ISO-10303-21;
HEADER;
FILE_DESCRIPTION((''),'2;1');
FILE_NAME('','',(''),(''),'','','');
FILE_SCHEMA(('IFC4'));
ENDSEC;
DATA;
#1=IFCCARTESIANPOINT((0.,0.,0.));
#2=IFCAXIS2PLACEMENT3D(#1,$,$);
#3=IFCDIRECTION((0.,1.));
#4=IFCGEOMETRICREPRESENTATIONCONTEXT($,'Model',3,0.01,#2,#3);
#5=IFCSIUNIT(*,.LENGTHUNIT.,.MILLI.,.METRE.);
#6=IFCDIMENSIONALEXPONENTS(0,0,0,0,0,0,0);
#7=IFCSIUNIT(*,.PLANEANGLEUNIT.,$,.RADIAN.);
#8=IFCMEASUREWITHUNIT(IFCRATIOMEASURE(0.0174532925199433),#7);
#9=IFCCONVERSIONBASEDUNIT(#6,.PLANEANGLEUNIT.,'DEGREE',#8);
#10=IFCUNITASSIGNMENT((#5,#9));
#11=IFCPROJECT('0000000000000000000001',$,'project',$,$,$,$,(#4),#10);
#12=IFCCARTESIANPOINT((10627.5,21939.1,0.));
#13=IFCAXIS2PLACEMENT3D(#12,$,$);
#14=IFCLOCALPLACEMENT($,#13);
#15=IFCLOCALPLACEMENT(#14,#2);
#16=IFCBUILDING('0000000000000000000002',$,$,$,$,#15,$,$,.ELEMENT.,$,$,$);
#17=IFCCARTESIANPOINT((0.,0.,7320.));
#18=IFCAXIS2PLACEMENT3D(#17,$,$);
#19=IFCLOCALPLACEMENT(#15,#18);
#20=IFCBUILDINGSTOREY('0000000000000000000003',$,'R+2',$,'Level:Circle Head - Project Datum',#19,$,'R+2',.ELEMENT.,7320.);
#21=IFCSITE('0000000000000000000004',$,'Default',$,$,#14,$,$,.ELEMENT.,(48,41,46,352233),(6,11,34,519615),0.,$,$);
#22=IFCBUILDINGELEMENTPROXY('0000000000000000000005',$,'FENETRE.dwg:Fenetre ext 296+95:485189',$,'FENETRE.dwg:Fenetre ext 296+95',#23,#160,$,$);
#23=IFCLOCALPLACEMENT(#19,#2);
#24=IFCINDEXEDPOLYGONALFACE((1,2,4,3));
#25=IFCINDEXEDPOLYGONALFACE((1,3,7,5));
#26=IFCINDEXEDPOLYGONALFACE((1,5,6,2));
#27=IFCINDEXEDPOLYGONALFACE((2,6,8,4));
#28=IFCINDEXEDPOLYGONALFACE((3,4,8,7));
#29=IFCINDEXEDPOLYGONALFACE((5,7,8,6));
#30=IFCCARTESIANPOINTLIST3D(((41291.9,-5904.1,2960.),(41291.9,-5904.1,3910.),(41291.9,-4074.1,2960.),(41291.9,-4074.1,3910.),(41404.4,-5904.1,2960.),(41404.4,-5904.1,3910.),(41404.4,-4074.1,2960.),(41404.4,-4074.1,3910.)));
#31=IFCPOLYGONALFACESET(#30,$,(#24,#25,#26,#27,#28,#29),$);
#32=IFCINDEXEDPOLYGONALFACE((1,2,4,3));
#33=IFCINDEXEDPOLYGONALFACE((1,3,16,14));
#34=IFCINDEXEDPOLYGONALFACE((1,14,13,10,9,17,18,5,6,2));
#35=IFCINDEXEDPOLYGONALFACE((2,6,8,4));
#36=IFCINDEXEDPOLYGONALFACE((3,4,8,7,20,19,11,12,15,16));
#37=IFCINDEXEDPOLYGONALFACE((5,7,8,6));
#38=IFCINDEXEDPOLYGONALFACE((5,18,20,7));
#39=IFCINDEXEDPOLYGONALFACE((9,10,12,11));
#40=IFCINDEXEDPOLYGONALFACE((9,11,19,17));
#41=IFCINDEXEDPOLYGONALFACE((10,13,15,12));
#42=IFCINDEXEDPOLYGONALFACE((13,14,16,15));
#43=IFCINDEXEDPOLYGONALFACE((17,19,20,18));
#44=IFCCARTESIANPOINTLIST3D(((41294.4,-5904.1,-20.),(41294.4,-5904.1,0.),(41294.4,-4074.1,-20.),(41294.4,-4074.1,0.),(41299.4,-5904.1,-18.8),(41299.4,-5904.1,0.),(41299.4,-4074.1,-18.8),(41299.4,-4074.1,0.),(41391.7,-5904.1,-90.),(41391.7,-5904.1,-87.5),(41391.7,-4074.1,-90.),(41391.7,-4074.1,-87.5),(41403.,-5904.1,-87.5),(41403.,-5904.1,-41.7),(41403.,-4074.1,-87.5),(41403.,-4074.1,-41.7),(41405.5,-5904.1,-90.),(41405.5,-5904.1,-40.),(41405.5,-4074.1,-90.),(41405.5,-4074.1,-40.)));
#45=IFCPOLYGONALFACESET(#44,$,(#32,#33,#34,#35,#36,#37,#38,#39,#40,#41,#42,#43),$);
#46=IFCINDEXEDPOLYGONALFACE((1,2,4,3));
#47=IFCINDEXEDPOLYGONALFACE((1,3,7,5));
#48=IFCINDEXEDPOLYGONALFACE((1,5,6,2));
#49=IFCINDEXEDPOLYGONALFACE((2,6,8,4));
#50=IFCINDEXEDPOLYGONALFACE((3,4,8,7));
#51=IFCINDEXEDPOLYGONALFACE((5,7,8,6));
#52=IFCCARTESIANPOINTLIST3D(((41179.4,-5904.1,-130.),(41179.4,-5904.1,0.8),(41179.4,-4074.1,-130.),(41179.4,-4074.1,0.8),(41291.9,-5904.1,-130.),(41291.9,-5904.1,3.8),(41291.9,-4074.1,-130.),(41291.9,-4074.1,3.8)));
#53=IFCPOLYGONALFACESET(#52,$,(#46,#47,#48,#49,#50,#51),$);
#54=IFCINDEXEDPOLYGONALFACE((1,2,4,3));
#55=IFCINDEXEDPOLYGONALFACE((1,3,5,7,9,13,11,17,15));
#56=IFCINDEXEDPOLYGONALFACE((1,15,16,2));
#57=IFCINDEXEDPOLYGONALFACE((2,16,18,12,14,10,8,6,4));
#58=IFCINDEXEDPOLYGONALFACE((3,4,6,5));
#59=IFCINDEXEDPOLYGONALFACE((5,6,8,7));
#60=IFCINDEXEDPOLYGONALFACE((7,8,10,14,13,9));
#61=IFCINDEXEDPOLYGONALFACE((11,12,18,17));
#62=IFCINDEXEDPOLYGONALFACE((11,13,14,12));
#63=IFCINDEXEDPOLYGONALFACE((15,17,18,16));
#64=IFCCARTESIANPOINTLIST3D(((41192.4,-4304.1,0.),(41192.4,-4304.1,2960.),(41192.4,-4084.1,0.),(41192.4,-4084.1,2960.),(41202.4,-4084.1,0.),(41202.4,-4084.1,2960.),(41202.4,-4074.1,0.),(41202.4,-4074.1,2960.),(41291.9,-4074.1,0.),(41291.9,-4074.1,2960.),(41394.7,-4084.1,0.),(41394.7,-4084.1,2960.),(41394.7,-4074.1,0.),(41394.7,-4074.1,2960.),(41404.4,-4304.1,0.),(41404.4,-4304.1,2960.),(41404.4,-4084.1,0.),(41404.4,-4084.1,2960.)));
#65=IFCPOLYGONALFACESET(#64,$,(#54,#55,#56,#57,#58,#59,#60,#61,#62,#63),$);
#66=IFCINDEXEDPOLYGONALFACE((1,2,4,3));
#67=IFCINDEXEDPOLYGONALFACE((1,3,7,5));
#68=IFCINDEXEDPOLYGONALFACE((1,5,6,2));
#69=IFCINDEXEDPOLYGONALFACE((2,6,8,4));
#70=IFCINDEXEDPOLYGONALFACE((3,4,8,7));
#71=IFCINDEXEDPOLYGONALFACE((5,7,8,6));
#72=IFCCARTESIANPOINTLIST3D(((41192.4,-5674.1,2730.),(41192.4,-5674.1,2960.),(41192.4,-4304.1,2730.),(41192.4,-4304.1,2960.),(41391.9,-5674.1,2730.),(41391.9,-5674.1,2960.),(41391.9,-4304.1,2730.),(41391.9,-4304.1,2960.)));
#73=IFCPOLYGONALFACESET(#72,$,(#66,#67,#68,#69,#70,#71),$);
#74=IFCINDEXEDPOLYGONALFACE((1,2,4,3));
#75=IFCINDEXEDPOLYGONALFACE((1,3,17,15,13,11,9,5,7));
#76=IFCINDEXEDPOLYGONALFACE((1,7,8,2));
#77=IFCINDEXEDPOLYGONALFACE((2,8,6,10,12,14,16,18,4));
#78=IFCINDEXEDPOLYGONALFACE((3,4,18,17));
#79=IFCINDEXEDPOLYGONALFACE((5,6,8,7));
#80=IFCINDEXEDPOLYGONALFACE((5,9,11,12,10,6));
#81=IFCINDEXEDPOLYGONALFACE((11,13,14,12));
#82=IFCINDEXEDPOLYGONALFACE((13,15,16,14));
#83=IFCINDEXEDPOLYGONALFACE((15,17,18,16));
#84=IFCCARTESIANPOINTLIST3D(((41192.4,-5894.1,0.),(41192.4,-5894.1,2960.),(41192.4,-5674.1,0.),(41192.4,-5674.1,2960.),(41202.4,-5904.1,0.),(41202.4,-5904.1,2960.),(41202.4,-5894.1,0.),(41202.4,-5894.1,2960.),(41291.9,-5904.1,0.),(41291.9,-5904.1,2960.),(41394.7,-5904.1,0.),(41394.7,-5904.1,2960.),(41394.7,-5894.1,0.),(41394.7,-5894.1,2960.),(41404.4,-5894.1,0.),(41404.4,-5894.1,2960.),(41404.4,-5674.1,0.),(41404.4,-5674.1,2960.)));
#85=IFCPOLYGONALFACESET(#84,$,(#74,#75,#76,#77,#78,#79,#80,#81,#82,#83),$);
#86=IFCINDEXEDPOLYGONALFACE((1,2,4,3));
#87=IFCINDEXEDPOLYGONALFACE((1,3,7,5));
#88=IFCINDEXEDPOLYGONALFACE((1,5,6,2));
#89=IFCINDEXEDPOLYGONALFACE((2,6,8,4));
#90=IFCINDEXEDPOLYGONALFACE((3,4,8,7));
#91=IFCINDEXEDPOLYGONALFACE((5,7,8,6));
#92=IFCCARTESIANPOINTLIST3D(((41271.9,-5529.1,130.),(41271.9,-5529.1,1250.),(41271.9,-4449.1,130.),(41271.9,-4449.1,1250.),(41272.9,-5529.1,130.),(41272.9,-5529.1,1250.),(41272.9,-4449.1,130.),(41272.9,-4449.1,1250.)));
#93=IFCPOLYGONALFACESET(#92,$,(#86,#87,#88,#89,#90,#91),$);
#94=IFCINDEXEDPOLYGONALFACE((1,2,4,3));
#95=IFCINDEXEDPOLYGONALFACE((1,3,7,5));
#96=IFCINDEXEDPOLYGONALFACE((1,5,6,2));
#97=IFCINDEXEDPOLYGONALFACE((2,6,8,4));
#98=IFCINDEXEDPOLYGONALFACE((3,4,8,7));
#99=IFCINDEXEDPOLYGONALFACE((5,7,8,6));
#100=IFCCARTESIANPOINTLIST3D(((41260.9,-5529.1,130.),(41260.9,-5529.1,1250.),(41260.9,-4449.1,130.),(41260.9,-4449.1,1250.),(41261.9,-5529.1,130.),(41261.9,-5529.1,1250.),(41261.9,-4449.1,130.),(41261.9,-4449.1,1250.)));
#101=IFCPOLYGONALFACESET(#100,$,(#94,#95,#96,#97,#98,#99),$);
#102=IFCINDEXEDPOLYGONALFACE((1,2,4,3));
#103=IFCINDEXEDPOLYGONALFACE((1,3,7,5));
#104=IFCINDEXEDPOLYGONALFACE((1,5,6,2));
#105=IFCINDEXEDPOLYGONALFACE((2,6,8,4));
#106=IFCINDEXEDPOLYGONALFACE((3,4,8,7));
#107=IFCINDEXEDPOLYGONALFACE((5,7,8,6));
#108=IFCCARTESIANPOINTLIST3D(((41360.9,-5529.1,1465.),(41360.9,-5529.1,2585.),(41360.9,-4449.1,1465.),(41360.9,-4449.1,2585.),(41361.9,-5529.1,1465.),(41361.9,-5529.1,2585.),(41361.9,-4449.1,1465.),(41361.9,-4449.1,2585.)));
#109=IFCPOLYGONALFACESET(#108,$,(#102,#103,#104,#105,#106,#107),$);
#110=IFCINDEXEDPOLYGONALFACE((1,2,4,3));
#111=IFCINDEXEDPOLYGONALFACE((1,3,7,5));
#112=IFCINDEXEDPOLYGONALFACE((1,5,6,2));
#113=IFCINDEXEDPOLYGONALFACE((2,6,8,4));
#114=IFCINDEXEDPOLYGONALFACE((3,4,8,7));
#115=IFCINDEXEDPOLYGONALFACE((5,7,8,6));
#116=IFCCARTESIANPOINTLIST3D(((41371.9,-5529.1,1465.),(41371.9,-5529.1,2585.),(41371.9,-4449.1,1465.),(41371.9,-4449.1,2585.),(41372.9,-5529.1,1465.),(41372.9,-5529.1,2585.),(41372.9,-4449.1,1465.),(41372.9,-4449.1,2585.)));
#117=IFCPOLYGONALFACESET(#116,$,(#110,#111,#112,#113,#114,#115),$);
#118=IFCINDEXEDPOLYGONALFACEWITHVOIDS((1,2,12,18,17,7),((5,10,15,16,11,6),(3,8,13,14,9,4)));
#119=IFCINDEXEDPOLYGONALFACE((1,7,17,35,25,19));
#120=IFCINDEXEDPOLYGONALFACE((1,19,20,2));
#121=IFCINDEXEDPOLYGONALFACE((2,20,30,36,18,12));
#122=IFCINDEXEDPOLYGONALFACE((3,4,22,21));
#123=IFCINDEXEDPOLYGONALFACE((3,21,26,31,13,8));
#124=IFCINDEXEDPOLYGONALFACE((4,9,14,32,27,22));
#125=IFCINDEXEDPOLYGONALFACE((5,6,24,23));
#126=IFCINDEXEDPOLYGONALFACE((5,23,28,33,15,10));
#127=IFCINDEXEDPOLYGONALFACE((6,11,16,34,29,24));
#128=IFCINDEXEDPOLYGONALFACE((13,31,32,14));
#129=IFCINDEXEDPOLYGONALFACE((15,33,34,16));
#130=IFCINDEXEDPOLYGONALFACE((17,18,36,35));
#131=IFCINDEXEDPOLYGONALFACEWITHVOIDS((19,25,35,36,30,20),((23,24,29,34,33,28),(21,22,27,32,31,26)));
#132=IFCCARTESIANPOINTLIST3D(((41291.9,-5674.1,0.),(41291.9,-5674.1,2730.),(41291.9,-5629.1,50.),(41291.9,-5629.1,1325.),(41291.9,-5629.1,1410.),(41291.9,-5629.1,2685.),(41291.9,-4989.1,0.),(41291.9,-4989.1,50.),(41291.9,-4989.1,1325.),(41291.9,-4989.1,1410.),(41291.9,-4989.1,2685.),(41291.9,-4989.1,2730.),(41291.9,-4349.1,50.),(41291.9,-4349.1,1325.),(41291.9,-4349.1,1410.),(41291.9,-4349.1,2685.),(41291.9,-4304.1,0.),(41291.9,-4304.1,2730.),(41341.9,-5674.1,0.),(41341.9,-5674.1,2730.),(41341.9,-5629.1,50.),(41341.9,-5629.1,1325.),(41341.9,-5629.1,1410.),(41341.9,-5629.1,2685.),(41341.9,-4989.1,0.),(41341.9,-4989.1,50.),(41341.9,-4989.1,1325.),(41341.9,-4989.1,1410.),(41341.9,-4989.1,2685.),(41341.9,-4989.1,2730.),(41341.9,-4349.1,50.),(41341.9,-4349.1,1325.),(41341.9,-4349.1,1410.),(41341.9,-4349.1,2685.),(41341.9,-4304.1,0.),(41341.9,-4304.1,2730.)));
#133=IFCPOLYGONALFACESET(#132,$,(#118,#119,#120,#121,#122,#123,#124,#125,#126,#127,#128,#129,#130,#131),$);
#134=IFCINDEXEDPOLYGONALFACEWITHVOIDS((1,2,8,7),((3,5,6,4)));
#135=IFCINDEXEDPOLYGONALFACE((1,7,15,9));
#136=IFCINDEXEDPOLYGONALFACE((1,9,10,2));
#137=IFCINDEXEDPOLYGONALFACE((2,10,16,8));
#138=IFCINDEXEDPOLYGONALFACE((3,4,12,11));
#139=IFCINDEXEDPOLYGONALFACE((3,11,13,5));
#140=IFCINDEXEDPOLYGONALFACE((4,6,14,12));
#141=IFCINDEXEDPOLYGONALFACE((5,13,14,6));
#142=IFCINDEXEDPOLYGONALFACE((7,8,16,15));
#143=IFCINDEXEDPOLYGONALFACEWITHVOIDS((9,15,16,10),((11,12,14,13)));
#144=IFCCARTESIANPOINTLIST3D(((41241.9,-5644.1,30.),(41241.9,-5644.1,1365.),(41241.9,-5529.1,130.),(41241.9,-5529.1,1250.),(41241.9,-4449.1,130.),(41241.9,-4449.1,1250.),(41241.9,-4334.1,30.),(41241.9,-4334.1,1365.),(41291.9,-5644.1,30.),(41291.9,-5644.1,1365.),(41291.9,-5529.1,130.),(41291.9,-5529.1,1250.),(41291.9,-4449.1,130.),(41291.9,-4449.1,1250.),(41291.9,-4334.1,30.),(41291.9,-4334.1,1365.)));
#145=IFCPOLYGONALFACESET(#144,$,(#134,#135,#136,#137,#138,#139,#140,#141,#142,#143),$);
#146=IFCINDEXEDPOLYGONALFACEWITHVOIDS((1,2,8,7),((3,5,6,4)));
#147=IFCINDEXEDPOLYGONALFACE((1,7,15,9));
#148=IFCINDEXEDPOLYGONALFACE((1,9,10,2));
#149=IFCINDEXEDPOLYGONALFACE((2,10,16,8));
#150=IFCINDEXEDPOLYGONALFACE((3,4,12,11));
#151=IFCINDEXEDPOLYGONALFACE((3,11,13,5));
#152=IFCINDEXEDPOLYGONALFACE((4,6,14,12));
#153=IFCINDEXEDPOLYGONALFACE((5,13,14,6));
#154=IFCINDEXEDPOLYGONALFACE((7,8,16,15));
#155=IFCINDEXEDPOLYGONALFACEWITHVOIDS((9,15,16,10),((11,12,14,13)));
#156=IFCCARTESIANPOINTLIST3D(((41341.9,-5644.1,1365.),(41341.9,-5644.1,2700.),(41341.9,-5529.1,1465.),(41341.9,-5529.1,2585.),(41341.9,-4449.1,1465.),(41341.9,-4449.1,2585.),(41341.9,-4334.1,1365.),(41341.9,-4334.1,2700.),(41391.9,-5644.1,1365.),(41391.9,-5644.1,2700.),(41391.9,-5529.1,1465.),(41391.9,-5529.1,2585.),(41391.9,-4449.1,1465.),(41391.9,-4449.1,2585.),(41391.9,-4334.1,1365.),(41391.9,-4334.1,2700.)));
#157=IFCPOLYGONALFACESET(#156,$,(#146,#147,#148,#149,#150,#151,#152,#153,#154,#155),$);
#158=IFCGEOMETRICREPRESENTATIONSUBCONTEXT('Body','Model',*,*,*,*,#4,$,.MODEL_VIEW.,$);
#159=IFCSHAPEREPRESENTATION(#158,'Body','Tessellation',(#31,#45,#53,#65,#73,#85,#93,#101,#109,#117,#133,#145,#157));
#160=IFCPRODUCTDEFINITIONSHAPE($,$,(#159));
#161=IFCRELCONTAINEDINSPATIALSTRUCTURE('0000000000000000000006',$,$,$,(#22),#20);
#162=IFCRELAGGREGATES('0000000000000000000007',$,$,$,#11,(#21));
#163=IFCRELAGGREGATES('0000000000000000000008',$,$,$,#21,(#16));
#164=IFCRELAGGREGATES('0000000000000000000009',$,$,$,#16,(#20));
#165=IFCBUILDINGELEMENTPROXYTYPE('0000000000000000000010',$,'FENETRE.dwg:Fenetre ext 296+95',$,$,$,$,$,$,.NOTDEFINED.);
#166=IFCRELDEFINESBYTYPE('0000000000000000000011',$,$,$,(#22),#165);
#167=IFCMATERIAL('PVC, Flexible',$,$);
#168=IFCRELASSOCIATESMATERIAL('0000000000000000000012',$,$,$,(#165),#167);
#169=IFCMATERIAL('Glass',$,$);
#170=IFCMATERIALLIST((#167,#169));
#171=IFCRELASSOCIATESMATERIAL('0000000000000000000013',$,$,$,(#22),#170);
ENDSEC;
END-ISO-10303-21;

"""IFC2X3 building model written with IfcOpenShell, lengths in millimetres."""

from ifc_helpers import new_model, entity, si_unit, converted_unit, direction, frame, frame_2d, origin, origin_2d_with_axis, place, context, subcontext, project, spatial, polyline, rectangle, outline, extrude, source, transform, mapped, material, material_list, type_object, type_shapes, element, save


model = new_model("IFC2X3")

# Units and contexts
model_context = context("Model", 3, precision=0.01, world=origin(), true_north=direction((0.0, 1.0)))
body_context = subcontext(model_context, "Body", "Model", "MODEL_VIEW")
ifc_project = project(units=[si_unit("LENGTHUNIT", "METRE", prefix="MILLI"), converted_unit("PLANEANGLEUNIT", "DEGREE", entity("IfcRatioMeasure", 0.0174532925199433), si_unit("PLANEANGLEUNIT", "RADIAN"), dimensions=[0, 0, 0, 0, 0, 0, 0])], contexts=[model_context])

# Site, building, storey
site_placement = place(None, frame((10627.5, 21939.1, 0.0)))
site = spatial("IfcSite", under=ifc_project, at=site_placement, Name="Default", CompositionType="ELEMENT", RefLatitude=(48, 41, 46, 352233), RefLongitude=(6, 11, 34, 519615), RefElevation=0.0)
building_placement = place(site_placement, origin())
building = spatial("IfcBuilding", under=site, at=building_placement, CompositionType="ELEMENT")
storey_placement = place(building_placement, frame((0.0, 0.0, 7320.0)))
storey = spatial("IfcBuildingStorey", under=building, at=storey_placement, Name="R+2", ObjectType="Level:Circle Head - Project Datum", LongName="R+2", CompositionType="ELEMENT", Elevation=7320.0)

# Building element proxy
ifc_material_1 = material(Name="PVC, Flexible")
ifc_material_2 = material(Name="Glass")
building_element_proxy_type_1 = type_object("IfcBuildingElementProxyType", Name="FENETRE.dwg:Fenetre ext 296+95", PredefinedType="NOTDEFINED", material=ifc_material_1)
shared_shape_1 = source(origin(), body_context, "Body", "SweptSolid", [
    extrude(rectangle(XDim=112.5, YDim=1830.0, at=origin_2d_with_axis()), frame((-10.4, -56.3, 2960.0), z_axis=(0.0, 0.0, 1.0), x_axis=(0.0, 1.0, 0.0)), (0.0, 0.0, 1.0), 950.0),
    extrude(outline(polyline([(27.5, -64.4), (47.5, -64.4), (47.5, -59.4), (28.8, -59.4), (7.5, 46.7), (-42.5, 46.7), (-42.5, 32.9), (-40.0, 32.9), (-40.0, 44.2), (5.8, 44.2), (27.5, -64.4)])), frame((-925.4, -66.9, -47.5), z_axis=(1.0, 0.0, 0.0), x_axis=(0.0, 0.0, 1.0)), (0.0, 0.0, 1.0), 1830.0),
    extrude(outline(polyline([(-54.5, -66.1), (58.0, -66.1), (54.5, 67.6), (-58.0, 64.6), (-54.5, -66.1)])), frame((-925.4, 56.3, -63.8), z_axis=(1.0, 0.0, 0.0), x_axis=(0.0, -0.999645, 0.02665)), (0.0, 0.0, 1.0), 1830.0),
    extrude(outline(polyline([(-97.0, -55.6), (5.9, -55.6), (95.4, -55.6), (95.4, -45.6), (105.4, -45.6), (105.4, 174.4), (-106.6, 174.4), (-106.6, -45.6), (-97.0, -45.6), (-97.0, -55.6)])), frame((849.0, -5.9, 0.0), z_axis=(0.0, 0.0, 1.0), x_axis=(0.0, 1.0, 0.0)), (0.0, 0.0, 1.0), 2960.0),
    extrude(rectangle(XDim=1370.0, YDim=199.5, at=origin_2d_with_axis()), frame((-10.4, -0.3, 2730.0), z_axis=(0.0, 0.0, 1.0), x_axis=(-1.0, 0.0, 0.0)), (0.0, 0.0, 1.0), 230.0),
    extrude(outline(polyline([(-55.6, 97.0), (-55.6, -5.9), (-55.6, -95.4), (-45.6, -95.4), (-45.6, -105.4), (174.4, -105.4), (174.4, 106.6), (-45.6, 106.6), (-45.6, 97.0), (-55.6, 97.0)])), frame((-869.9, -5.9, 0.0), z_axis=(0.0, 0.0, -1.0), x_axis=(1.0, 0.0, 0.0)), (0.0, 0.0, -1.0), 2960.0),
    extrude(rectangle(XDim=1080.0, YDim=1.0, at=origin_2d_with_axis()), frame((-10.4, 19.5, 130.0), z_axis=(0.0, 0.0, 1.0), x_axis=(-1.0, 0.0, 0.0)), (0.0, 0.0, 1.0), 1120.0),
    extrude(rectangle(XDim=1080.0, YDim=1.0, at=origin_2d_with_axis()), frame((-10.4, 30.5, 130.0), z_axis=(0.0, 0.0, 1.0), x_axis=(-1.0, 0.0, 0.0)), (0.0, 0.0, 1.0), 1120.0),
    extrude(rectangle(XDim=1080.0, YDim=1.0, at=frame_2d((0.0, 0.0), x_axis=(1.0, 0.0))), frame((-10.4, -69.5, 1465.0), z_axis=(0.0, 0.0, 1.0), x_axis=(-1.0, 0.0, 0.0)), (0.0, 0.0, 1.0), 1120.0),
    extrude(rectangle(XDim=1080.0, YDim=1.0, at=frame_2d((0.0, 0.0), x_axis=(1.0, 0.0))), frame((-10.4, -80.5, 1465.0), z_axis=(0.0, 0.0, 1.0), x_axis=(-1.0, 0.0, 0.0)), (0.0, 0.0, 1.0), 1120.0),
    extrude(outline(polyline([(-685.0, -1365.0), (0.0, -1365.0), (685.0, -1365.0), (685.0, 1365.0), (0.0, 1365.0), (-685.0, 1365.0), (-685.0, -1365.0)]), holes=[polyline([(-640.0, -1320.0), (-640.0, -45.0), (0.0, -45.0), (640.0, -45.0), (640.0, -1320.0), (0.0, -1320.0), (-640.0, -1320.0)]), polyline([(-640.0, 40.0), (-640.0, 1315.0), (0.0, 1315.0), (640.0, 1315.0), (640.0, 40.0), (0.0, 40.0), (-640.0, 40.0)])]), frame((-10.4, -50.0, 1365.0), z_axis=(0.0, 1.0, 0.0), x_axis=(1.0, 0.0, 0.0)), (0.0, 0.0, 1.0), 50.0),
    extrude(outline(polyline([(-655.0, -667.5), (655.0, -667.5), (655.0, 667.5), (-655.0, 667.5), (-655.0, -667.5)]), holes=[polyline([(-540.0, 552.5), (540.0, 552.5), (540.0, -567.5), (-540.0, -567.5), (-540.0, 552.5)])]), frame((-10.4, 0.0, 697.5), z_axis=(0.0, 1.0, 0.0), x_axis=(-1.0, 0.0, 0.0)), (0.0, 0.0, 1.0), 50.0),
    extrude(outline(polyline([(-655.0, -667.5), (655.0, -667.5), (655.0, 667.5), (-655.0, 667.5), (-655.0, -667.5)]), holes=[polyline([(-540.0, 552.5), (540.0, 552.5), (540.0, -567.5), (-540.0, -567.5), (-540.0, 552.5)])]), frame((-10.4, -100.0, 2032.5), z_axis=(0.0, 1.0, 0.0), x_axis=(-1.0, 0.0, 0.0)), (0.0, 0.0, 1.0), 50.0),
])
type_shapes(building_element_proxy_type_1, [shared_shape_1])
ifc_material_list_1 = material_list([ifc_material_1, ifc_material_2])
proxy_1_placement = place(storey_placement, frame((41291.9, -4978.7, 0.0), z_axis=(0.0, 0.0, 1.0), x_axis=(0.0, 1.0, 0.0)))
element("IfcBuildingElementProxy", 1, at=proxy_1_placement, inside=storey, type_object=building_element_proxy_type_1, material=ifc_material_list_1, Name="FENETRE.dwg:Fenetre ext 296+95:485189", ObjectType="FENETRE.dwg:Fenetre ext 296+95", context=body_context, shape_type="MappedRepresentation", body=[
    mapped(shared_shape_1, transform((0.0, 0.0, 0.0), scale=1.0)),
])

save(model, "model.ifc")
